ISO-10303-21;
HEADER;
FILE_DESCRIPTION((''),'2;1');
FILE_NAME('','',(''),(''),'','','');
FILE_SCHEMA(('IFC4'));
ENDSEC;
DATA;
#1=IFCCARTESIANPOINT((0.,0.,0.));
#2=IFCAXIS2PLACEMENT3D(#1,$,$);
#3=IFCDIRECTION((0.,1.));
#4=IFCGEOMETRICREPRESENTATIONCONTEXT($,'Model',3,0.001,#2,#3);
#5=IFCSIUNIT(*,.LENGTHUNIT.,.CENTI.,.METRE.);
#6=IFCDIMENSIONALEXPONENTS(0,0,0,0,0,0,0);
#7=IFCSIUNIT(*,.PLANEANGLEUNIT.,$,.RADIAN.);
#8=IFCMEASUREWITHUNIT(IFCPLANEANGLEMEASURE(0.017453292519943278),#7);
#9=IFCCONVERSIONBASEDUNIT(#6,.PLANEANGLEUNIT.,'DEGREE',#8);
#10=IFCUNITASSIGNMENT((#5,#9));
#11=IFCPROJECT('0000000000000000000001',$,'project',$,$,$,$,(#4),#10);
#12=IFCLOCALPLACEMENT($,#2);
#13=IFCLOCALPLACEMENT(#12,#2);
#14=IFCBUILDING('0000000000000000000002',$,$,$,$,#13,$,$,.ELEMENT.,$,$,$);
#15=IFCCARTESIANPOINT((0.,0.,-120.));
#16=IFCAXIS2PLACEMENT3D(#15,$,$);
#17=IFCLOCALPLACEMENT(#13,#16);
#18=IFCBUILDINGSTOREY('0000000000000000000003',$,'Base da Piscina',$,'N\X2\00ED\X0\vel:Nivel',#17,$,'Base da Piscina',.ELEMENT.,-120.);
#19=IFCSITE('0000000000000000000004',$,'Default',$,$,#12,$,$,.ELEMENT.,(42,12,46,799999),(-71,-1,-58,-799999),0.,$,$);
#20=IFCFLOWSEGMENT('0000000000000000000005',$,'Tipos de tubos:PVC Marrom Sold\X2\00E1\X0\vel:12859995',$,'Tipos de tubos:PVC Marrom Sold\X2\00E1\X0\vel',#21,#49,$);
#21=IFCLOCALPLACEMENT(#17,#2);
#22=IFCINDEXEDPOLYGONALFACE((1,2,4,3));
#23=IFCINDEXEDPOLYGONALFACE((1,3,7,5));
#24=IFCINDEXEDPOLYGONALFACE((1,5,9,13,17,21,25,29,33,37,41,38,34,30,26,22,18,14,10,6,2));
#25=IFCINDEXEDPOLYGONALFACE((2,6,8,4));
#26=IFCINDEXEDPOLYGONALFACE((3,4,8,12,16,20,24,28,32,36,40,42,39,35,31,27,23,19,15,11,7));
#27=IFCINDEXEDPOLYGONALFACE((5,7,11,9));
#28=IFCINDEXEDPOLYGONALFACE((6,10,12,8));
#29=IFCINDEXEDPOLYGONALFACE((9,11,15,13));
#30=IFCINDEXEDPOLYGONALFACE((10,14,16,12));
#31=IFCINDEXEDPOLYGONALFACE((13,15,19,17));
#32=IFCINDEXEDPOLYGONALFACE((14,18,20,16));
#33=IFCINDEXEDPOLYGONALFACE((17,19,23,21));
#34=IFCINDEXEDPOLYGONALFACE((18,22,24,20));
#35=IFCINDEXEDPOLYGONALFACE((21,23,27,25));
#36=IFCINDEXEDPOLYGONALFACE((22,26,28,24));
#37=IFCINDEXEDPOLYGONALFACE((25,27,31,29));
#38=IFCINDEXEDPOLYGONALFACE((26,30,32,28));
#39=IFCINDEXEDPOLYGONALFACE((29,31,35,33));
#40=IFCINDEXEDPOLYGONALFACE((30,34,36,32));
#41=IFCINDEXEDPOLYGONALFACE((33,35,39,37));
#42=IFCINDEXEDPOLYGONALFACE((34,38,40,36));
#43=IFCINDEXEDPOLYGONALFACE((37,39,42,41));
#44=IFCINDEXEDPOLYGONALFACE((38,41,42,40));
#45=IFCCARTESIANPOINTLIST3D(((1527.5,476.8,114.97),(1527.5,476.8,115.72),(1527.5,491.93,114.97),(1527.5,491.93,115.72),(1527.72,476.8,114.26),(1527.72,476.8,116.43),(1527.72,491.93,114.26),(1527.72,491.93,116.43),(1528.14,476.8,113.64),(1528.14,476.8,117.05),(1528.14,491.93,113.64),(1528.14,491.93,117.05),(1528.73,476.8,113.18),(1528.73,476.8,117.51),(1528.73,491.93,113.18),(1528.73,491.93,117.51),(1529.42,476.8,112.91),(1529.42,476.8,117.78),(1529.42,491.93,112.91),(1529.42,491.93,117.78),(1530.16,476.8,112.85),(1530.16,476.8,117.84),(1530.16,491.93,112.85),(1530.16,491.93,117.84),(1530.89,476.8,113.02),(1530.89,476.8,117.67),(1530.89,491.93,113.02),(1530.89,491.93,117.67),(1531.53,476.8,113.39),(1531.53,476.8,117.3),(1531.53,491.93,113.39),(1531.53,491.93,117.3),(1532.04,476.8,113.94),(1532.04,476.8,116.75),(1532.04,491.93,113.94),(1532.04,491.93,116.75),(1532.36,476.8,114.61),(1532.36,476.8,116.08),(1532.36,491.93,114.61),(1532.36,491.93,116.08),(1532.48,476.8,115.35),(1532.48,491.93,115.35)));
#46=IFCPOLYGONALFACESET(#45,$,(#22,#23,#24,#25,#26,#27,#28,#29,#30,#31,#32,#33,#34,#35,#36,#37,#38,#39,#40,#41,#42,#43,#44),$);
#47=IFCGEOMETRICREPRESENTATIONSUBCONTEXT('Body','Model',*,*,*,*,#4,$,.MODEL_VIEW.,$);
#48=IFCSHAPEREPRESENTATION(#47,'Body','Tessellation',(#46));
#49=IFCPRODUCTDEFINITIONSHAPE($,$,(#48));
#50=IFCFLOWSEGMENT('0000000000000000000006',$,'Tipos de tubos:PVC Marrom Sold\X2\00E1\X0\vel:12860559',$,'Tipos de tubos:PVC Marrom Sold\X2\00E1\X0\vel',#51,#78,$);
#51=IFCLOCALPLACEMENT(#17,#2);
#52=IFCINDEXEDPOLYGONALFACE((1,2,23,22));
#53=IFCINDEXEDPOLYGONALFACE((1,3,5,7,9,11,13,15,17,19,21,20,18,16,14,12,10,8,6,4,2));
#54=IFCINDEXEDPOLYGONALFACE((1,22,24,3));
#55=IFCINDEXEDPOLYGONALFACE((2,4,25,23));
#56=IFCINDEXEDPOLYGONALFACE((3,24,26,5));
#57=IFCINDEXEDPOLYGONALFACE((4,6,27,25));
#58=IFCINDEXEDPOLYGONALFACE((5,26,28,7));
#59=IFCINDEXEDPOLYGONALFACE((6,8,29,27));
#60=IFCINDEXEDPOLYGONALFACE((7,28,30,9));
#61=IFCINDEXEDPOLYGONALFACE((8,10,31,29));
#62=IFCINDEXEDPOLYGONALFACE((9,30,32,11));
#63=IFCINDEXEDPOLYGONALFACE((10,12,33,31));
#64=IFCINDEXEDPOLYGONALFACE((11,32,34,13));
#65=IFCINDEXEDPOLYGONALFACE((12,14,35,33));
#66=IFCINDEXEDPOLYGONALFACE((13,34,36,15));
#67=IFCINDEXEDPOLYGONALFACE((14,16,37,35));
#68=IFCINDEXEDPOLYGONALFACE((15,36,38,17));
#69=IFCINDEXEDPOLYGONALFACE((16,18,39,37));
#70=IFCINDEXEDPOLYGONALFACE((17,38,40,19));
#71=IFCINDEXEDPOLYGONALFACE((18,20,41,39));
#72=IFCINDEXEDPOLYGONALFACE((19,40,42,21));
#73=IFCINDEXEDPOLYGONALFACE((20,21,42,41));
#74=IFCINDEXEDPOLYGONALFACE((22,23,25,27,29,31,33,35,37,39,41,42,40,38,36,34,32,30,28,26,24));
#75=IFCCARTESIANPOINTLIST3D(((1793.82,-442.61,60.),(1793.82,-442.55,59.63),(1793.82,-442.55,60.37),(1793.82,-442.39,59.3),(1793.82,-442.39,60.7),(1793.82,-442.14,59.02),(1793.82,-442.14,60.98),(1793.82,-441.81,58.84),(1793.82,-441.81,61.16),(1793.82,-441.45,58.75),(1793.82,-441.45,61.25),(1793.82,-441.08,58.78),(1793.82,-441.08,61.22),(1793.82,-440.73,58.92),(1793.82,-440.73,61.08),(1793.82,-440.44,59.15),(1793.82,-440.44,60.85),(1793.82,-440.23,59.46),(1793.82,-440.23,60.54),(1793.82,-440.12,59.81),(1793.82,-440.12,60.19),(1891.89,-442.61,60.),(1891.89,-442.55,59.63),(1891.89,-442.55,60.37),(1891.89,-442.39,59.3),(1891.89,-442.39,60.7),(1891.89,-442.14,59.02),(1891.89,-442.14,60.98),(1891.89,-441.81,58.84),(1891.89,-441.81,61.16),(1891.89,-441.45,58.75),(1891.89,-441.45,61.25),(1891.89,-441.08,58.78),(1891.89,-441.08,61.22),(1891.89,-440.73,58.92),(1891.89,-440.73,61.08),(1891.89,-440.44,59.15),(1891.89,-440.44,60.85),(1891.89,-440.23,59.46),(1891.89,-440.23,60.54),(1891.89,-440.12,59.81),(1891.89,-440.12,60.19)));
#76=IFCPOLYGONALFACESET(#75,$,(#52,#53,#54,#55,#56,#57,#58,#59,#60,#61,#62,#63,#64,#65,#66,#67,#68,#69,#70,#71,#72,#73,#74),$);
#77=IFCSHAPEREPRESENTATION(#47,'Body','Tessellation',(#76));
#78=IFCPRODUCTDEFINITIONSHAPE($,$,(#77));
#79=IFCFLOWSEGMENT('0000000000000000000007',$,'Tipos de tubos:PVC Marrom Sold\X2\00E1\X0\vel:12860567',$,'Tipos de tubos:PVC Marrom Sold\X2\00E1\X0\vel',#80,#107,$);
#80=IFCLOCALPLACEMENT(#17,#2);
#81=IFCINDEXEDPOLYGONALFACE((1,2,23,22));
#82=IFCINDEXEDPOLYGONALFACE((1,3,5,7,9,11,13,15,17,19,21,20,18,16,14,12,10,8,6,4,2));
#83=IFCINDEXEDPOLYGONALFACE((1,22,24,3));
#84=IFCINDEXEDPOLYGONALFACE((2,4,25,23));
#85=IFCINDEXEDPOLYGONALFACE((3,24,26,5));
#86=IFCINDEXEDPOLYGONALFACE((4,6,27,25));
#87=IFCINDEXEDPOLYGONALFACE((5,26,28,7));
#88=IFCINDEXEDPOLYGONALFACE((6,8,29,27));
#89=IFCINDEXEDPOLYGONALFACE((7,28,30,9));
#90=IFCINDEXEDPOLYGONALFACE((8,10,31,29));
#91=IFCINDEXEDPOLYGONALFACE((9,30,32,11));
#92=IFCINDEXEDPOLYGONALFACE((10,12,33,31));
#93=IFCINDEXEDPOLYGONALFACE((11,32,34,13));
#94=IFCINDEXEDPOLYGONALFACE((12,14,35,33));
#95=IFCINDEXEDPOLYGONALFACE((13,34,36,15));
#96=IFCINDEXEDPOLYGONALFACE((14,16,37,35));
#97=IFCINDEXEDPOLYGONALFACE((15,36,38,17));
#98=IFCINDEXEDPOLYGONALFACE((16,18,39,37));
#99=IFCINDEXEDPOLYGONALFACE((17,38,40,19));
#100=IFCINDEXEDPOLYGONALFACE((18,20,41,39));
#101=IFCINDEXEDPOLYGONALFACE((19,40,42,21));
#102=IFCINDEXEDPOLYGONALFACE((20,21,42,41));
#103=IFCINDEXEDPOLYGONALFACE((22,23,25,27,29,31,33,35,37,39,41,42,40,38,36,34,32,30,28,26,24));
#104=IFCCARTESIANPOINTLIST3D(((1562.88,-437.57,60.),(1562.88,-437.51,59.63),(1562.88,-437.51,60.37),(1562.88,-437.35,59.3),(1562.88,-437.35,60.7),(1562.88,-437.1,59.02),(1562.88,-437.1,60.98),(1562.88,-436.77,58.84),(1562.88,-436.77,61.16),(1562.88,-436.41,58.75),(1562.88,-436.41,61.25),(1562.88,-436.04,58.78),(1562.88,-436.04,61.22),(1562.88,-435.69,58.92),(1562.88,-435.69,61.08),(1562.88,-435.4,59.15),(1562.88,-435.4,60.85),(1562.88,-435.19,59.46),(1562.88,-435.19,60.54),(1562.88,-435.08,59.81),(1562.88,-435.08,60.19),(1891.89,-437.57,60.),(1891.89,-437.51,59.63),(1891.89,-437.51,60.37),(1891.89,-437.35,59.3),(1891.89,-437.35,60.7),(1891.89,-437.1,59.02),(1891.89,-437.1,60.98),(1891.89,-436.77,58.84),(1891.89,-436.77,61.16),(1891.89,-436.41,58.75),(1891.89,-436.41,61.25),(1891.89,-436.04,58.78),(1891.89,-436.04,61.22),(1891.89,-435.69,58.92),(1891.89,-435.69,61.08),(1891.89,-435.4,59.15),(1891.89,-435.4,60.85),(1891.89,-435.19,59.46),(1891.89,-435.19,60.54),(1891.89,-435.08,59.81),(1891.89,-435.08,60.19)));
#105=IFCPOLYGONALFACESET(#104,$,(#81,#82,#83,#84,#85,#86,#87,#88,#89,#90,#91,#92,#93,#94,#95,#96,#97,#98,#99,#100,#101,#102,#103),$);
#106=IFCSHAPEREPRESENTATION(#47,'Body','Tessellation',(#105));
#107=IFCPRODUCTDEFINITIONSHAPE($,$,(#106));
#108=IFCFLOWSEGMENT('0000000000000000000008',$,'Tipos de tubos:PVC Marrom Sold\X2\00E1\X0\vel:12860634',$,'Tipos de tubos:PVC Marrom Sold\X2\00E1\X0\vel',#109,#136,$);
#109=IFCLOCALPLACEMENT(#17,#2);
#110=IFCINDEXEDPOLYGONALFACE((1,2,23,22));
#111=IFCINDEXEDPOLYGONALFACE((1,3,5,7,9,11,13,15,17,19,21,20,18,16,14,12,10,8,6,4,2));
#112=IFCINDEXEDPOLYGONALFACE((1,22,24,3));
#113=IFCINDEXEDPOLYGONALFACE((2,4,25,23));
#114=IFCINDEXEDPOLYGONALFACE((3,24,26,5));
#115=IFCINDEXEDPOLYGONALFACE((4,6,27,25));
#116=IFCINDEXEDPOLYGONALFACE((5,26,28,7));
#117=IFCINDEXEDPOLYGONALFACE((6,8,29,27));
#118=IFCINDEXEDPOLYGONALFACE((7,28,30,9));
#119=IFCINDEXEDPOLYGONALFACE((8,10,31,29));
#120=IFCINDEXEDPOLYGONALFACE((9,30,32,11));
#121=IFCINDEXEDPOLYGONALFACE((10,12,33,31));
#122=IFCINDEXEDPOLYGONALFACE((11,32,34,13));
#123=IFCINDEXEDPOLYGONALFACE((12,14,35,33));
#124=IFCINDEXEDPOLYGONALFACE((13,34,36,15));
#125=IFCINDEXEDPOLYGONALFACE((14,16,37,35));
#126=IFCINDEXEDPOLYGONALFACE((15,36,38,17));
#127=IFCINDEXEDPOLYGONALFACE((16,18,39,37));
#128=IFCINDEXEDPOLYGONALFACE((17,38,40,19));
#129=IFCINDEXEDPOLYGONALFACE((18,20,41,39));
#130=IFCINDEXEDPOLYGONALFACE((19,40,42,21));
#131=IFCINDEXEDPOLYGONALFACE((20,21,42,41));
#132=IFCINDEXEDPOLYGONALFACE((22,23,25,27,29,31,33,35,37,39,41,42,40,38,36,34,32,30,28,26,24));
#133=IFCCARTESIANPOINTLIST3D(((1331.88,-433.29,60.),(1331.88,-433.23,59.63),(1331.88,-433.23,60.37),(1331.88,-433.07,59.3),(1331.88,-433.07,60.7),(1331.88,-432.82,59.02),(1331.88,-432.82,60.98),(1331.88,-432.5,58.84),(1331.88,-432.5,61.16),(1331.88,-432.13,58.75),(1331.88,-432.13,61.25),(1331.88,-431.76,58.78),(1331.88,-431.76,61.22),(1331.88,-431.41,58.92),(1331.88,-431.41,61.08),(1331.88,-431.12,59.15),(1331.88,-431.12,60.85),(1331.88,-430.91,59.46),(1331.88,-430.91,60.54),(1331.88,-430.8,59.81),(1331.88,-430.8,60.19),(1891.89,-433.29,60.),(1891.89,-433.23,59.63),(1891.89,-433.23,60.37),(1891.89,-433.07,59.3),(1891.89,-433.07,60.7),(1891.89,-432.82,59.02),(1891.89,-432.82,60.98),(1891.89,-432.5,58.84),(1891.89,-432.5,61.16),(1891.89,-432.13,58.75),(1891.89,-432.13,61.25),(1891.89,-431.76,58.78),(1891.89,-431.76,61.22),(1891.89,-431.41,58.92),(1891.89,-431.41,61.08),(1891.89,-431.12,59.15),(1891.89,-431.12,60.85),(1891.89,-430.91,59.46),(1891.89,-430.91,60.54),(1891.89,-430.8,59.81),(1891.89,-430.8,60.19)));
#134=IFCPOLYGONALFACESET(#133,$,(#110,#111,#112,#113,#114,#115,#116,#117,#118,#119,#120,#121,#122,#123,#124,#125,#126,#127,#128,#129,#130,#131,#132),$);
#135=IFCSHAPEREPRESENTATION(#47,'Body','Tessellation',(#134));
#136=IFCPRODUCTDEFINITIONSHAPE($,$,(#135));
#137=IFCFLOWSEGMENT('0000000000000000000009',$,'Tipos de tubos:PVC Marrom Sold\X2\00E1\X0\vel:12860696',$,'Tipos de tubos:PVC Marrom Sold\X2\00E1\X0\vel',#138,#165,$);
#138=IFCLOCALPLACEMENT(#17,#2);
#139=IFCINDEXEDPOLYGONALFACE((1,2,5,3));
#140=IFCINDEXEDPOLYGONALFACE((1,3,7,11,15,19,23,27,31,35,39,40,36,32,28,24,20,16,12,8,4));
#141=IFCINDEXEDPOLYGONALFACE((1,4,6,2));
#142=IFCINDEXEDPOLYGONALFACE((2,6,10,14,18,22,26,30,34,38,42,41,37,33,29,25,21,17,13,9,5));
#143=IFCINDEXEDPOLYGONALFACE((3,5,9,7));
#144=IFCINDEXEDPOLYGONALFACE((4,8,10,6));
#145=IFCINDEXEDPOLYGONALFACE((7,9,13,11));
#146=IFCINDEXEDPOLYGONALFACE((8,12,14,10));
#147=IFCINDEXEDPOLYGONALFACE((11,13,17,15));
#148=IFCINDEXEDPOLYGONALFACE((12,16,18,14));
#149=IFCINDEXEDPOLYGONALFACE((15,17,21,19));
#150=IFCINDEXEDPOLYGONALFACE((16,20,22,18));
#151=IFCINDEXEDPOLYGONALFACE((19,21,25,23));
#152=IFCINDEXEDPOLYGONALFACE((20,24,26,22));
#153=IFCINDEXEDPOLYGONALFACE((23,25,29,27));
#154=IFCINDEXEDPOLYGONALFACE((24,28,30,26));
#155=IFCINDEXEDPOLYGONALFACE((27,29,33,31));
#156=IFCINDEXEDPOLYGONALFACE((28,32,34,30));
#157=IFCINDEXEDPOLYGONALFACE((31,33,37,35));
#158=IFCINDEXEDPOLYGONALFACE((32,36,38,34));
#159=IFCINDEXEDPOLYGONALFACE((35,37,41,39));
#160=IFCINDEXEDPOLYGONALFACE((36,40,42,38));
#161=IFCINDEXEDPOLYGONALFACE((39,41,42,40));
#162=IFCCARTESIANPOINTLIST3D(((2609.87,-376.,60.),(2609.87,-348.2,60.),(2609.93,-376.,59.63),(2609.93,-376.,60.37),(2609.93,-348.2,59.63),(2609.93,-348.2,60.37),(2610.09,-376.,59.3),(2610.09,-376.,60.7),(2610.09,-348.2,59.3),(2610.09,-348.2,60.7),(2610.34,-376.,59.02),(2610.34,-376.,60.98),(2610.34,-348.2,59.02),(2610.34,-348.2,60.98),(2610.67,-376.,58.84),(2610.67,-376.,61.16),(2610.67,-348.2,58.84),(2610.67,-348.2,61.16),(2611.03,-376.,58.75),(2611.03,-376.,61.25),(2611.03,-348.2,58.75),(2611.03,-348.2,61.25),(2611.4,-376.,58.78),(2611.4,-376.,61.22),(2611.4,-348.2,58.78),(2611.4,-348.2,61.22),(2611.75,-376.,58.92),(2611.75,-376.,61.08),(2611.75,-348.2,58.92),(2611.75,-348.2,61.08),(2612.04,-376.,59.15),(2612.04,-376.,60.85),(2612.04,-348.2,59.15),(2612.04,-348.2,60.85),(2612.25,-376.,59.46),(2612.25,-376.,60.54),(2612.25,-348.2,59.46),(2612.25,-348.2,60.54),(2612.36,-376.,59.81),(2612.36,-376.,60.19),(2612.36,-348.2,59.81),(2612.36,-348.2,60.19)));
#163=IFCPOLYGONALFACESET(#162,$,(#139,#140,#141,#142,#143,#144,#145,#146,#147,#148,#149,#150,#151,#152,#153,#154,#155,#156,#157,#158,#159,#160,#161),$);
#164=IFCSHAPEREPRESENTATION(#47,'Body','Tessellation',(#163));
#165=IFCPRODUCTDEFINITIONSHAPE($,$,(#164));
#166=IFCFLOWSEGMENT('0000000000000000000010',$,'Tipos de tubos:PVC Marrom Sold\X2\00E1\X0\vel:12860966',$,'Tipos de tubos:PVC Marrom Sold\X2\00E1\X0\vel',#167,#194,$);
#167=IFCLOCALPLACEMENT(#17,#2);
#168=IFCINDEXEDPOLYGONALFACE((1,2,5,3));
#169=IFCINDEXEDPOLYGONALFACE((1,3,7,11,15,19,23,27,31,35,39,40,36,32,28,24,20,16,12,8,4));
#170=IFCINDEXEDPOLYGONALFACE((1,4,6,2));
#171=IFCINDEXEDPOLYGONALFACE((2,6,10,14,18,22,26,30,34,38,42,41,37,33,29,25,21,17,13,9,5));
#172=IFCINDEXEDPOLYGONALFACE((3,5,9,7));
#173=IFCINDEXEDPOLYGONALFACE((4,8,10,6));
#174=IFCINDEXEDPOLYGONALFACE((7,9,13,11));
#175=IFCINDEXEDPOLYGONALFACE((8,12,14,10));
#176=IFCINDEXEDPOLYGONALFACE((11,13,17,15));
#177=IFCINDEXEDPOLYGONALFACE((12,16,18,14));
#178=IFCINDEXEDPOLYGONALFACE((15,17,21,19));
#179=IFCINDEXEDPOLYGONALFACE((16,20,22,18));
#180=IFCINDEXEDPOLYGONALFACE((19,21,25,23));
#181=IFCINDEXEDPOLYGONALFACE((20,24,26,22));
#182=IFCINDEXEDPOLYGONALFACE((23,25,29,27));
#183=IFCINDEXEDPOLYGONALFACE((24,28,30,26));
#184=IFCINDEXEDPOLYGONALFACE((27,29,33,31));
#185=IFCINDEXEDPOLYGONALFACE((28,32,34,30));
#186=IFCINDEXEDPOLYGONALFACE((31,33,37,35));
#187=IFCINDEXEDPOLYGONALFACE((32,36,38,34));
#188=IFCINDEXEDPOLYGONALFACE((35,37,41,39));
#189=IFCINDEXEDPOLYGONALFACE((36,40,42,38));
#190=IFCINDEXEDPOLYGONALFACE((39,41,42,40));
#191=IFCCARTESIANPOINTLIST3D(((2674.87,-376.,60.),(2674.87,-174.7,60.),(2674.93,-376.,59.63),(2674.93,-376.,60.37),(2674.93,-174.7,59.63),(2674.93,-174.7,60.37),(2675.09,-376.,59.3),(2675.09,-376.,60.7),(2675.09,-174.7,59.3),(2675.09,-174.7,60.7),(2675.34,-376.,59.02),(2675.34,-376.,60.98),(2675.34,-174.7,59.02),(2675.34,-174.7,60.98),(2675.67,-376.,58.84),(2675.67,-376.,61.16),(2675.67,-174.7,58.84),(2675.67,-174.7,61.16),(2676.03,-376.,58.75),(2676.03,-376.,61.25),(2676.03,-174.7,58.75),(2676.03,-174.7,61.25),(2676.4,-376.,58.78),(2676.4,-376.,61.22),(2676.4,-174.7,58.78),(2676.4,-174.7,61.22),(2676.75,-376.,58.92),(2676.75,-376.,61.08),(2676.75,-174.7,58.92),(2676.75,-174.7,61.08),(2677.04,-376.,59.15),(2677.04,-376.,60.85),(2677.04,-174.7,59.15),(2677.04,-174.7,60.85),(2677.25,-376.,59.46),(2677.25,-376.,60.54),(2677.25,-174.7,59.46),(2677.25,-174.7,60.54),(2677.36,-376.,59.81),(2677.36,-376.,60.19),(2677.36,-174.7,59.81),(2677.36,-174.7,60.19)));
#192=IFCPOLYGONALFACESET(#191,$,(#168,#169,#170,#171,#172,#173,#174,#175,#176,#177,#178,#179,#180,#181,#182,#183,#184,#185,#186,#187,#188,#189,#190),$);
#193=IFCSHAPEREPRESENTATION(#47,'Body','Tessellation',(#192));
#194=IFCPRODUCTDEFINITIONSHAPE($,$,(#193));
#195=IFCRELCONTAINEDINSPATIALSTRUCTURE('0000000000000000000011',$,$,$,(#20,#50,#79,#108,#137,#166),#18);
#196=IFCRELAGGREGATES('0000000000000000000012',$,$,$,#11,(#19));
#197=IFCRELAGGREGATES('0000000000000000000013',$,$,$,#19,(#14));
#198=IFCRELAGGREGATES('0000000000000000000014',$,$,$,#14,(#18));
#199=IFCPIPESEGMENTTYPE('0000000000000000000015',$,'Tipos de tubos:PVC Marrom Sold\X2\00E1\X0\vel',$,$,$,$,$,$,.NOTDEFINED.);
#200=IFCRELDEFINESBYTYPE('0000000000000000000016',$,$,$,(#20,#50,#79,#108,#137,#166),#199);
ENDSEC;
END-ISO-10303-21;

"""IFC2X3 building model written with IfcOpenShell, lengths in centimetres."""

from ifc_helpers import new_model, entity, si_unit, converted_unit, direction, frame, frame_2d, origin, origin_2d_with_axis, place, context, subcontext, project, spatial, circle, extrude, type_object, element, save


model = new_model("IFC2X3")

# Units and contexts
model_context = context("Model", 3, precision=0.001, world=origin(), true_north=direction((0.0, 1.0)))
body_context = subcontext(model_context, "Body", "Model", "MODEL_VIEW")
ifc_project = project(units=[si_unit("LENGTHUNIT", "METRE", prefix="CENTI"), converted_unit("PLANEANGLEUNIT", "DEGREE", entity("IfcPlaneAngleMeasure", 0.017453292519943278), si_unit("PLANEANGLEUNIT", "RADIAN"), dimensions=[0, 0, 0, 0, 0, 0, 0])], contexts=[model_context])

# Site, building, storey
site_placement = place(None, origin())
site = spatial("IfcSite", under=ifc_project, at=site_placement, Name="Default", CompositionType="ELEMENT", RefLatitude=(42, 12, 46, 799999), RefLongitude=(-71, -1, -58, -799999), RefElevation=0.0)
building_placement = place(site_placement, origin())
building = spatial("IfcBuilding", under=site, at=building_placement, CompositionType="ELEMENT")
storey_placement = place(building_placement, frame((0.0, 0.0, -120.0)))
storey = spatial("IfcBuildingStorey", under=building, at=storey_placement, Name="Base da Piscina", ObjectType="Nível:Nivel", LongName="Base da Piscina", CompositionType="ELEMENT", Elevation=-120.0)

# Flow segments
pipe_segment_type = type_object("IfcPipeSegmentType", Name="Tipos de tubos:PVC Marrom Soldável", PredefinedType="NOTDEFINED")
flow_segment_1_placement = place(storey_placement, origin())
element("IfcFlowSegment", 1, at=flow_segment_1_placement, inside=storey, type_object=pipe_segment_type, Name="Tipos de tubos:PVC Marrom Soldável:12859995", ObjectType="Tipos de tubos:PVC Marrom Soldável", context=body_context, shape_type="SweptSolid", body=[
    extrude(circle(Radius=2.5, at=frame_2d((0.0, 0.0), x_axis=(1.0, 0.0))), frame((1529.98, 476.8, 115.35), z_axis=(0.0, 1.0, 0.0), x_axis=(1.0, 0.0, 0.0)), (0.0, 0.0, 1.0), 15.13),
])
flow_segment_2_placement = place(storey_placement, origin())
element("IfcFlowSegment", 2, at=flow_segment_2_placement, inside=storey, type_object=pipe_segment_type, Name="Tipos de tubos:PVC Marrom Soldável:12860559", ObjectType="Tipos de tubos:PVC Marrom Soldável", context=body_context, shape_type="SweptSolid", body=[
    extrude(circle(Radius=1.25, at=origin_2d_with_axis()), frame((1793.82, -441.36, 60.0), z_axis=(1.0, 0.0, 0.0), x_axis=(0.0, -1.0, 0.0)), (0.0, 0.0, 1.0), 98.07),
])
flow_segment_3_placement = place(storey_placement, origin())
element("IfcFlowSegment", 3, at=flow_segment_3_placement, inside=storey, type_object=pipe_segment_type, Name="Tipos de tubos:PVC Marrom Soldável:12860567", ObjectType="Tipos de tubos:PVC Marrom Soldável", context=body_context, shape_type="SweptSolid", body=[
    extrude(circle(Radius=1.25, at=origin_2d_with_axis()), frame((1562.88, -436.32, 60.0), z_axis=(1.0, 0.0, 0.0), x_axis=(0.0, -1.0, 0.0)), (0.0, 0.0, 1.0), 329.01),
])
flow_segment_4_placement = place(storey_placement, origin())
element("IfcFlowSegment", 4, at=flow_segment_4_placement, inside=storey, type_object=pipe_segment_type, Name="Tipos de tubos:PVC Marrom Soldável:12860634", ObjectType="Tipos de tubos:PVC Marrom Soldável", context=body_context, shape_type="SweptSolid", body=[
    extrude(circle(Radius=1.25, at=origin_2d_with_axis()), frame((1331.88, -432.04, 60.0), z_axis=(1.0, 0.0, 0.0), x_axis=(0.0, -1.0, 0.0)), (0.0, 0.0, 1.0), 560.01),
])
flow_segment_5_placement = place(storey_placement, origin())
element("IfcFlowSegment", 5, at=flow_segment_5_placement, inside=storey, type_object=pipe_segment_type, Name="Tipos de tubos:PVC Marrom Soldável:12860696", ObjectType="Tipos de tubos:PVC Marrom Soldável", context=body_context, shape_type="SweptSolid", body=[
    extrude(circle(Radius=1.25, at=origin_2d_with_axis()), frame((2611.12, -376.0, 60.0), z_axis=(0.0, 1.0, 0.0), x_axis=(-1.0, 0.0, 0.0)), (0.0, 0.0, 1.0), 27.8),
])
flow_segment_6_placement = place(storey_placement, origin())
element("IfcFlowSegment", 6, at=flow_segment_6_placement, inside=storey, type_object=pipe_segment_type, Name="Tipos de tubos:PVC Marrom Soldável:12860966", ObjectType="Tipos de tubos:PVC Marrom Soldável", context=body_context, shape_type="SweptSolid", body=[
    extrude(circle(Radius=1.25, at=frame_2d((0.0, 0.0), x_axis=(1.0, 0.0))), frame((2676.12, -376.0, 60.0), z_axis=(0.0, 1.0, 0.0), x_axis=(-1.0, 0.0, 0.0)), (0.0, 0.0, 1.0), 201.3),
])

save(model, "model.ifc")
